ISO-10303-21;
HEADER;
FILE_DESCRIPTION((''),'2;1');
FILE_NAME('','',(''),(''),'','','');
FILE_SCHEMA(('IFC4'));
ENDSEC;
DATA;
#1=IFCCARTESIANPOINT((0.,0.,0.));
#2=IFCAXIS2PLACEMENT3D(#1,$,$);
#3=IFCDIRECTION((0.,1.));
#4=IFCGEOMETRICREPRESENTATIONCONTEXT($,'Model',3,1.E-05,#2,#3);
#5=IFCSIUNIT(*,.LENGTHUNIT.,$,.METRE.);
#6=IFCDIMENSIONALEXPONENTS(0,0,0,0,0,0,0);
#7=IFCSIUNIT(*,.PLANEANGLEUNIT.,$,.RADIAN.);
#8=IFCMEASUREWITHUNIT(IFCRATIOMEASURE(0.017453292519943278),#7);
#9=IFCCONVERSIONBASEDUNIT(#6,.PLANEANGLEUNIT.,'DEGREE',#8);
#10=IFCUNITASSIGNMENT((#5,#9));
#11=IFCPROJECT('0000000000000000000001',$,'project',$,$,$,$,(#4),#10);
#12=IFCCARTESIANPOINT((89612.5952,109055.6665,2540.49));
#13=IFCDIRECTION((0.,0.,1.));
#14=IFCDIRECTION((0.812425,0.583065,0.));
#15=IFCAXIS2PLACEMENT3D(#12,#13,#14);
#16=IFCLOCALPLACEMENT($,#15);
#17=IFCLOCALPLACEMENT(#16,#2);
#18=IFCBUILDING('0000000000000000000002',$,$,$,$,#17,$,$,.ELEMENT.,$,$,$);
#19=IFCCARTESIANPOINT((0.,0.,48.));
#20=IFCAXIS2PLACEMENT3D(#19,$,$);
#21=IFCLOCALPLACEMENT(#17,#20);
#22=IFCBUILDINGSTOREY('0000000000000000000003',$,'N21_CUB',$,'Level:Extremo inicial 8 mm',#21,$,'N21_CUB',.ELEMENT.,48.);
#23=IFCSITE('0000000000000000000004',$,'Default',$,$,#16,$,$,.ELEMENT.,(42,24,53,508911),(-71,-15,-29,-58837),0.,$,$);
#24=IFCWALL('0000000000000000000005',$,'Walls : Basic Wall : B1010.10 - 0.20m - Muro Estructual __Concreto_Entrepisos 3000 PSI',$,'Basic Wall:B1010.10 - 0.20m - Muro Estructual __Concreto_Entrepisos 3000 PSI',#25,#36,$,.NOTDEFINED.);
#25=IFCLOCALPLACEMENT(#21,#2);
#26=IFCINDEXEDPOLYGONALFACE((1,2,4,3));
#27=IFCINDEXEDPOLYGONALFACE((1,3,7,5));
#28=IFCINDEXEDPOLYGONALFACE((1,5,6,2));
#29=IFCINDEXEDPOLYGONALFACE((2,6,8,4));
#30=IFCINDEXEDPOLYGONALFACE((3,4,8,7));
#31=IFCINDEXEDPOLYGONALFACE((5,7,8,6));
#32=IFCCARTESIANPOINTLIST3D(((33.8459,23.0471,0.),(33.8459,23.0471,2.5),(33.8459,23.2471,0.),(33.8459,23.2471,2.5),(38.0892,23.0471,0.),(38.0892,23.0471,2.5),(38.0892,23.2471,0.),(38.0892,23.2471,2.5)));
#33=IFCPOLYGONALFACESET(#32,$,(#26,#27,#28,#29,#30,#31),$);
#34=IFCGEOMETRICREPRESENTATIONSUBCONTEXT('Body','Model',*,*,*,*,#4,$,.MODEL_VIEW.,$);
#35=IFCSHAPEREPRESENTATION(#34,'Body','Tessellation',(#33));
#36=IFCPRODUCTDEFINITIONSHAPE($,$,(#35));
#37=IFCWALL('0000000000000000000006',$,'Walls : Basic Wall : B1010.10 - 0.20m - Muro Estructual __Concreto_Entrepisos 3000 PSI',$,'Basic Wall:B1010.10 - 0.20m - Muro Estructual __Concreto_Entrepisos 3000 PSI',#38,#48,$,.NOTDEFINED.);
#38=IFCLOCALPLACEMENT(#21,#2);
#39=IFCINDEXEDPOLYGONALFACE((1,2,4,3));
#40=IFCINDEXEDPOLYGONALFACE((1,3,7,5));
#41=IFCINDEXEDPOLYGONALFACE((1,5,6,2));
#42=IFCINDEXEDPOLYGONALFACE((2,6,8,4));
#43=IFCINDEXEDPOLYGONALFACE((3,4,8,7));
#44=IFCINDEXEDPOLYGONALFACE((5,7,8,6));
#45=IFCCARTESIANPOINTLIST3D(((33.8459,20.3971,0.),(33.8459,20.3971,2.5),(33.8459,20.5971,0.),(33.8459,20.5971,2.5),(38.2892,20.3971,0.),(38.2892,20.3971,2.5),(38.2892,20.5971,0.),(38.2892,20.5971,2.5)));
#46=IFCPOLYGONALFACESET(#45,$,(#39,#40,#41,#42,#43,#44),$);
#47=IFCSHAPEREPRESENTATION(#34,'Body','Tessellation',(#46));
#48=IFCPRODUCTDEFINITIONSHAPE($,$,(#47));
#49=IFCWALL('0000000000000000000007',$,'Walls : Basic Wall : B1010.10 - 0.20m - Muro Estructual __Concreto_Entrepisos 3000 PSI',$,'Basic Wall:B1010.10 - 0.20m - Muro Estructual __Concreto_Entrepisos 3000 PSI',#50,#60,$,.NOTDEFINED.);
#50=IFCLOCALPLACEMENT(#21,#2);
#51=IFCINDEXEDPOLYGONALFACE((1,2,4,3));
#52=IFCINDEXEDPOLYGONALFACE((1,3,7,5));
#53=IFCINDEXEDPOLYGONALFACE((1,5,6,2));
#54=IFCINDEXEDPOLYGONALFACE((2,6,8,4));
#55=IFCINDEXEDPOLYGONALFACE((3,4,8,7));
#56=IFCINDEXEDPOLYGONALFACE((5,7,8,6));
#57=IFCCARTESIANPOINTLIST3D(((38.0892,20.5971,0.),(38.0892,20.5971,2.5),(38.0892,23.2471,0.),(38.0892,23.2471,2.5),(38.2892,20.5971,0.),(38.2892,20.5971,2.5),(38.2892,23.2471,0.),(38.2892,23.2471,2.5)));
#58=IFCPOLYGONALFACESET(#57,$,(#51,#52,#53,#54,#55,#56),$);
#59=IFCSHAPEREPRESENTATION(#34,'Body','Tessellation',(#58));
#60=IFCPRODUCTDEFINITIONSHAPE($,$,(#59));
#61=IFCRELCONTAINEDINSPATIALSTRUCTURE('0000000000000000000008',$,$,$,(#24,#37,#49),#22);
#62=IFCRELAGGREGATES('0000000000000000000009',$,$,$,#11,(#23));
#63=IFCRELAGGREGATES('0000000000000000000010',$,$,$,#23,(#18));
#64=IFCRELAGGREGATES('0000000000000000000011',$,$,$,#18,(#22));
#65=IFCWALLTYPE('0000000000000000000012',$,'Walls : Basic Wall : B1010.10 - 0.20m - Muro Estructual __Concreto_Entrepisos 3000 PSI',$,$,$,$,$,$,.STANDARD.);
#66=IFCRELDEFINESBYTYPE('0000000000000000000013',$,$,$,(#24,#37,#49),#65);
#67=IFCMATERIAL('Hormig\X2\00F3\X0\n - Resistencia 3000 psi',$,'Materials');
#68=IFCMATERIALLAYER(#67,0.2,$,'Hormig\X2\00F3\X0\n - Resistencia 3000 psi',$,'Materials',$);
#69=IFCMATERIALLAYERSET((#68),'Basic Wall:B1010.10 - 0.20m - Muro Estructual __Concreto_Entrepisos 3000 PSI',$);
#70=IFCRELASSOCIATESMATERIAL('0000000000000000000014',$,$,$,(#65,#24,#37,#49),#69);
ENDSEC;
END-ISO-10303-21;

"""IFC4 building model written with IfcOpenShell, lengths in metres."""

from ifc_helpers import new_model, entity, si_unit, converted_unit, direction, frame, frame_2d, origin, place, context, subcontext, project, spatial, rectangle, extrude, material, layer, layer_set, layer_usage, type_object, element, save


model = new_model("IFC4")

# Units and contexts
model_context = context("Model", 3, precision=1e-05, world=origin(), true_north=direction((0.0, 1.0)))
body_context = subcontext(model_context, "Body", "Model", "MODEL_VIEW")
ifc_project = project(units=[si_unit("LENGTHUNIT", "METRE"), converted_unit("PLANEANGLEUNIT", "DEGREE", entity("IfcRatioMeasure", 0.017453292519943278), si_unit("PLANEANGLEUNIT", "RADIAN"), dimensions=[0, 0, 0, 0, 0, 0, 0])], contexts=[model_context])

# Site, building, storey
site_placement = place(None, frame((89612.5952, 109055.6665, 2540.49), z_axis=(0.0, 0.0, 1.0), x_axis=(0.812425, 0.583065, 0.0)))
site = spatial("IfcSite", under=ifc_project, at=site_placement, Name="Default", CompositionType="ELEMENT", RefLatitude=(42, 24, 53, 508911), RefLongitude=(-71, -15, -29, -58837), RefElevation=0.0)
building_placement = place(site_placement, origin())
building = spatial("IfcBuilding", under=site, at=building_placement, CompositionType="ELEMENT")
storey_placement = place(building_placement, frame((0.0, 0.0, 48.0)))
storey = spatial("IfcBuildingStorey", under=building, at=storey_placement, Name="N21_CUB", ObjectType="Level:Extremo inicial 8 mm", LongName="N21_CUB", CompositionType="ELEMENT", Elevation=48.0)

# Walls
ifc_material_1 = material(Name="Hormigón - Resistencia 3000 psi", Category="Materials")
ifc_layer_1 = layer(ifc_material_1, 0.2, Name="Hormigón - Resistencia 3000 psi", Category="Materials")
ifc_layer_set_1 = layer_set([ifc_layer_1], Name="Basic Wall:B1010.10 - 0.20m - Muro Estructual __Concreto_Entrepisos 3000 PSI")
ifc_layer_usage_1 = layer_usage(ifc_layer_set_1, "AXIS2", "POSITIVE", -0.1)
wall_type = type_object("IfcWallType", Name="Walls : Basic Wall : B1010.10 - 0.20m - Muro Estructual __Concreto_Entrepisos 3000 PSI", PredefinedType="STANDARD", material=ifc_layer_set_1)
wall_1_placement = place(storey_placement, frame((38.0892, 23.1471, 0.0), z_axis=(0.0, 0.0, 1.0), x_axis=(-1.0, 0.0, 0.0)))
element("IfcWall", 1, at=wall_1_placement, inside=storey, type_object=wall_type, material=ifc_layer_usage_1, Name="Walls : Basic Wall : B1010.10 - 0.20m - Muro Estructual __Concreto_Entrepisos 3000 PSI", ObjectType="Basic Wall:B1010.10 - 0.20m - Muro Estructual __Concreto_Entrepisos 3000 PSI", PredefinedType="NOTDEFINED", context=body_context, shape_type="SweptSolid", body=[
    extrude(rectangle(XDim=4.2433, YDim=0.2, at=frame_2d((2.1216, 0.0), x_axis=(-1.0, 0.0))), origin(), (0.0, 0.0, 1.0), 2.5),
])
ifc_layer_usage_2 = layer_usage(ifc_layer_set_1, "AXIS2", "POSITIVE", -0.1)
wall_2_placement = place(storey_placement, frame((38.2892, 20.4971, 0.0), z_axis=(0.0, 0.0, 1.0), x_axis=(-1.0, 0.0, 0.0)))
element("IfcWall", 2, at=wall_2_placement, inside=storey, type_object=wall_type, material=ifc_layer_usage_2, Name="Walls : Basic Wall : B1010.10 - 0.20m - Muro Estructual __Concreto_Entrepisos 3000 PSI", ObjectType="Basic Wall:B1010.10 - 0.20m - Muro Estructual __Concreto_Entrepisos 3000 PSI", PredefinedType="NOTDEFINED", context=body_context, shape_type="SweptSolid", body=[
    extrude(rectangle(XDim=4.4433, YDim=0.2, at=frame_2d((2.2216, 0.0), x_axis=(-1.0, 0.0))), origin(), (0.0, 0.0, 1.0), 2.5),
])
ifc_layer_usage_3 = layer_usage(ifc_layer_set_1, "AXIS2", "POSITIVE", -0.1)
wall_3_placement = place(storey_placement, frame((38.1892, 20.5971, 0.0), z_axis=(0.0, 0.0, 1.0), x_axis=(0.0, 1.0, 0.0)))
element("IfcWall", 3, at=wall_3_placement, inside=storey, type_object=wall_type, material=ifc_layer_usage_3, Name="Walls : Basic Wall : B1010.10 - 0.20m - Muro Estructual __Concreto_Entrepisos 3000 PSI", ObjectType="Basic Wall:B1010.10 - 0.20m - Muro Estructual __Concreto_Entrepisos 3000 PSI", PredefinedType="NOTDEFINED", context=body_context, shape_type="SweptSolid", body=[
    extrude(rectangle(XDim=2.65, YDim=0.2, at=frame_2d((1.325, 0.0), x_axis=(-1.0, 0.0))), origin(), (0.0, 0.0, 1.0), 2.5),
])

save(model, "model.ifc")
